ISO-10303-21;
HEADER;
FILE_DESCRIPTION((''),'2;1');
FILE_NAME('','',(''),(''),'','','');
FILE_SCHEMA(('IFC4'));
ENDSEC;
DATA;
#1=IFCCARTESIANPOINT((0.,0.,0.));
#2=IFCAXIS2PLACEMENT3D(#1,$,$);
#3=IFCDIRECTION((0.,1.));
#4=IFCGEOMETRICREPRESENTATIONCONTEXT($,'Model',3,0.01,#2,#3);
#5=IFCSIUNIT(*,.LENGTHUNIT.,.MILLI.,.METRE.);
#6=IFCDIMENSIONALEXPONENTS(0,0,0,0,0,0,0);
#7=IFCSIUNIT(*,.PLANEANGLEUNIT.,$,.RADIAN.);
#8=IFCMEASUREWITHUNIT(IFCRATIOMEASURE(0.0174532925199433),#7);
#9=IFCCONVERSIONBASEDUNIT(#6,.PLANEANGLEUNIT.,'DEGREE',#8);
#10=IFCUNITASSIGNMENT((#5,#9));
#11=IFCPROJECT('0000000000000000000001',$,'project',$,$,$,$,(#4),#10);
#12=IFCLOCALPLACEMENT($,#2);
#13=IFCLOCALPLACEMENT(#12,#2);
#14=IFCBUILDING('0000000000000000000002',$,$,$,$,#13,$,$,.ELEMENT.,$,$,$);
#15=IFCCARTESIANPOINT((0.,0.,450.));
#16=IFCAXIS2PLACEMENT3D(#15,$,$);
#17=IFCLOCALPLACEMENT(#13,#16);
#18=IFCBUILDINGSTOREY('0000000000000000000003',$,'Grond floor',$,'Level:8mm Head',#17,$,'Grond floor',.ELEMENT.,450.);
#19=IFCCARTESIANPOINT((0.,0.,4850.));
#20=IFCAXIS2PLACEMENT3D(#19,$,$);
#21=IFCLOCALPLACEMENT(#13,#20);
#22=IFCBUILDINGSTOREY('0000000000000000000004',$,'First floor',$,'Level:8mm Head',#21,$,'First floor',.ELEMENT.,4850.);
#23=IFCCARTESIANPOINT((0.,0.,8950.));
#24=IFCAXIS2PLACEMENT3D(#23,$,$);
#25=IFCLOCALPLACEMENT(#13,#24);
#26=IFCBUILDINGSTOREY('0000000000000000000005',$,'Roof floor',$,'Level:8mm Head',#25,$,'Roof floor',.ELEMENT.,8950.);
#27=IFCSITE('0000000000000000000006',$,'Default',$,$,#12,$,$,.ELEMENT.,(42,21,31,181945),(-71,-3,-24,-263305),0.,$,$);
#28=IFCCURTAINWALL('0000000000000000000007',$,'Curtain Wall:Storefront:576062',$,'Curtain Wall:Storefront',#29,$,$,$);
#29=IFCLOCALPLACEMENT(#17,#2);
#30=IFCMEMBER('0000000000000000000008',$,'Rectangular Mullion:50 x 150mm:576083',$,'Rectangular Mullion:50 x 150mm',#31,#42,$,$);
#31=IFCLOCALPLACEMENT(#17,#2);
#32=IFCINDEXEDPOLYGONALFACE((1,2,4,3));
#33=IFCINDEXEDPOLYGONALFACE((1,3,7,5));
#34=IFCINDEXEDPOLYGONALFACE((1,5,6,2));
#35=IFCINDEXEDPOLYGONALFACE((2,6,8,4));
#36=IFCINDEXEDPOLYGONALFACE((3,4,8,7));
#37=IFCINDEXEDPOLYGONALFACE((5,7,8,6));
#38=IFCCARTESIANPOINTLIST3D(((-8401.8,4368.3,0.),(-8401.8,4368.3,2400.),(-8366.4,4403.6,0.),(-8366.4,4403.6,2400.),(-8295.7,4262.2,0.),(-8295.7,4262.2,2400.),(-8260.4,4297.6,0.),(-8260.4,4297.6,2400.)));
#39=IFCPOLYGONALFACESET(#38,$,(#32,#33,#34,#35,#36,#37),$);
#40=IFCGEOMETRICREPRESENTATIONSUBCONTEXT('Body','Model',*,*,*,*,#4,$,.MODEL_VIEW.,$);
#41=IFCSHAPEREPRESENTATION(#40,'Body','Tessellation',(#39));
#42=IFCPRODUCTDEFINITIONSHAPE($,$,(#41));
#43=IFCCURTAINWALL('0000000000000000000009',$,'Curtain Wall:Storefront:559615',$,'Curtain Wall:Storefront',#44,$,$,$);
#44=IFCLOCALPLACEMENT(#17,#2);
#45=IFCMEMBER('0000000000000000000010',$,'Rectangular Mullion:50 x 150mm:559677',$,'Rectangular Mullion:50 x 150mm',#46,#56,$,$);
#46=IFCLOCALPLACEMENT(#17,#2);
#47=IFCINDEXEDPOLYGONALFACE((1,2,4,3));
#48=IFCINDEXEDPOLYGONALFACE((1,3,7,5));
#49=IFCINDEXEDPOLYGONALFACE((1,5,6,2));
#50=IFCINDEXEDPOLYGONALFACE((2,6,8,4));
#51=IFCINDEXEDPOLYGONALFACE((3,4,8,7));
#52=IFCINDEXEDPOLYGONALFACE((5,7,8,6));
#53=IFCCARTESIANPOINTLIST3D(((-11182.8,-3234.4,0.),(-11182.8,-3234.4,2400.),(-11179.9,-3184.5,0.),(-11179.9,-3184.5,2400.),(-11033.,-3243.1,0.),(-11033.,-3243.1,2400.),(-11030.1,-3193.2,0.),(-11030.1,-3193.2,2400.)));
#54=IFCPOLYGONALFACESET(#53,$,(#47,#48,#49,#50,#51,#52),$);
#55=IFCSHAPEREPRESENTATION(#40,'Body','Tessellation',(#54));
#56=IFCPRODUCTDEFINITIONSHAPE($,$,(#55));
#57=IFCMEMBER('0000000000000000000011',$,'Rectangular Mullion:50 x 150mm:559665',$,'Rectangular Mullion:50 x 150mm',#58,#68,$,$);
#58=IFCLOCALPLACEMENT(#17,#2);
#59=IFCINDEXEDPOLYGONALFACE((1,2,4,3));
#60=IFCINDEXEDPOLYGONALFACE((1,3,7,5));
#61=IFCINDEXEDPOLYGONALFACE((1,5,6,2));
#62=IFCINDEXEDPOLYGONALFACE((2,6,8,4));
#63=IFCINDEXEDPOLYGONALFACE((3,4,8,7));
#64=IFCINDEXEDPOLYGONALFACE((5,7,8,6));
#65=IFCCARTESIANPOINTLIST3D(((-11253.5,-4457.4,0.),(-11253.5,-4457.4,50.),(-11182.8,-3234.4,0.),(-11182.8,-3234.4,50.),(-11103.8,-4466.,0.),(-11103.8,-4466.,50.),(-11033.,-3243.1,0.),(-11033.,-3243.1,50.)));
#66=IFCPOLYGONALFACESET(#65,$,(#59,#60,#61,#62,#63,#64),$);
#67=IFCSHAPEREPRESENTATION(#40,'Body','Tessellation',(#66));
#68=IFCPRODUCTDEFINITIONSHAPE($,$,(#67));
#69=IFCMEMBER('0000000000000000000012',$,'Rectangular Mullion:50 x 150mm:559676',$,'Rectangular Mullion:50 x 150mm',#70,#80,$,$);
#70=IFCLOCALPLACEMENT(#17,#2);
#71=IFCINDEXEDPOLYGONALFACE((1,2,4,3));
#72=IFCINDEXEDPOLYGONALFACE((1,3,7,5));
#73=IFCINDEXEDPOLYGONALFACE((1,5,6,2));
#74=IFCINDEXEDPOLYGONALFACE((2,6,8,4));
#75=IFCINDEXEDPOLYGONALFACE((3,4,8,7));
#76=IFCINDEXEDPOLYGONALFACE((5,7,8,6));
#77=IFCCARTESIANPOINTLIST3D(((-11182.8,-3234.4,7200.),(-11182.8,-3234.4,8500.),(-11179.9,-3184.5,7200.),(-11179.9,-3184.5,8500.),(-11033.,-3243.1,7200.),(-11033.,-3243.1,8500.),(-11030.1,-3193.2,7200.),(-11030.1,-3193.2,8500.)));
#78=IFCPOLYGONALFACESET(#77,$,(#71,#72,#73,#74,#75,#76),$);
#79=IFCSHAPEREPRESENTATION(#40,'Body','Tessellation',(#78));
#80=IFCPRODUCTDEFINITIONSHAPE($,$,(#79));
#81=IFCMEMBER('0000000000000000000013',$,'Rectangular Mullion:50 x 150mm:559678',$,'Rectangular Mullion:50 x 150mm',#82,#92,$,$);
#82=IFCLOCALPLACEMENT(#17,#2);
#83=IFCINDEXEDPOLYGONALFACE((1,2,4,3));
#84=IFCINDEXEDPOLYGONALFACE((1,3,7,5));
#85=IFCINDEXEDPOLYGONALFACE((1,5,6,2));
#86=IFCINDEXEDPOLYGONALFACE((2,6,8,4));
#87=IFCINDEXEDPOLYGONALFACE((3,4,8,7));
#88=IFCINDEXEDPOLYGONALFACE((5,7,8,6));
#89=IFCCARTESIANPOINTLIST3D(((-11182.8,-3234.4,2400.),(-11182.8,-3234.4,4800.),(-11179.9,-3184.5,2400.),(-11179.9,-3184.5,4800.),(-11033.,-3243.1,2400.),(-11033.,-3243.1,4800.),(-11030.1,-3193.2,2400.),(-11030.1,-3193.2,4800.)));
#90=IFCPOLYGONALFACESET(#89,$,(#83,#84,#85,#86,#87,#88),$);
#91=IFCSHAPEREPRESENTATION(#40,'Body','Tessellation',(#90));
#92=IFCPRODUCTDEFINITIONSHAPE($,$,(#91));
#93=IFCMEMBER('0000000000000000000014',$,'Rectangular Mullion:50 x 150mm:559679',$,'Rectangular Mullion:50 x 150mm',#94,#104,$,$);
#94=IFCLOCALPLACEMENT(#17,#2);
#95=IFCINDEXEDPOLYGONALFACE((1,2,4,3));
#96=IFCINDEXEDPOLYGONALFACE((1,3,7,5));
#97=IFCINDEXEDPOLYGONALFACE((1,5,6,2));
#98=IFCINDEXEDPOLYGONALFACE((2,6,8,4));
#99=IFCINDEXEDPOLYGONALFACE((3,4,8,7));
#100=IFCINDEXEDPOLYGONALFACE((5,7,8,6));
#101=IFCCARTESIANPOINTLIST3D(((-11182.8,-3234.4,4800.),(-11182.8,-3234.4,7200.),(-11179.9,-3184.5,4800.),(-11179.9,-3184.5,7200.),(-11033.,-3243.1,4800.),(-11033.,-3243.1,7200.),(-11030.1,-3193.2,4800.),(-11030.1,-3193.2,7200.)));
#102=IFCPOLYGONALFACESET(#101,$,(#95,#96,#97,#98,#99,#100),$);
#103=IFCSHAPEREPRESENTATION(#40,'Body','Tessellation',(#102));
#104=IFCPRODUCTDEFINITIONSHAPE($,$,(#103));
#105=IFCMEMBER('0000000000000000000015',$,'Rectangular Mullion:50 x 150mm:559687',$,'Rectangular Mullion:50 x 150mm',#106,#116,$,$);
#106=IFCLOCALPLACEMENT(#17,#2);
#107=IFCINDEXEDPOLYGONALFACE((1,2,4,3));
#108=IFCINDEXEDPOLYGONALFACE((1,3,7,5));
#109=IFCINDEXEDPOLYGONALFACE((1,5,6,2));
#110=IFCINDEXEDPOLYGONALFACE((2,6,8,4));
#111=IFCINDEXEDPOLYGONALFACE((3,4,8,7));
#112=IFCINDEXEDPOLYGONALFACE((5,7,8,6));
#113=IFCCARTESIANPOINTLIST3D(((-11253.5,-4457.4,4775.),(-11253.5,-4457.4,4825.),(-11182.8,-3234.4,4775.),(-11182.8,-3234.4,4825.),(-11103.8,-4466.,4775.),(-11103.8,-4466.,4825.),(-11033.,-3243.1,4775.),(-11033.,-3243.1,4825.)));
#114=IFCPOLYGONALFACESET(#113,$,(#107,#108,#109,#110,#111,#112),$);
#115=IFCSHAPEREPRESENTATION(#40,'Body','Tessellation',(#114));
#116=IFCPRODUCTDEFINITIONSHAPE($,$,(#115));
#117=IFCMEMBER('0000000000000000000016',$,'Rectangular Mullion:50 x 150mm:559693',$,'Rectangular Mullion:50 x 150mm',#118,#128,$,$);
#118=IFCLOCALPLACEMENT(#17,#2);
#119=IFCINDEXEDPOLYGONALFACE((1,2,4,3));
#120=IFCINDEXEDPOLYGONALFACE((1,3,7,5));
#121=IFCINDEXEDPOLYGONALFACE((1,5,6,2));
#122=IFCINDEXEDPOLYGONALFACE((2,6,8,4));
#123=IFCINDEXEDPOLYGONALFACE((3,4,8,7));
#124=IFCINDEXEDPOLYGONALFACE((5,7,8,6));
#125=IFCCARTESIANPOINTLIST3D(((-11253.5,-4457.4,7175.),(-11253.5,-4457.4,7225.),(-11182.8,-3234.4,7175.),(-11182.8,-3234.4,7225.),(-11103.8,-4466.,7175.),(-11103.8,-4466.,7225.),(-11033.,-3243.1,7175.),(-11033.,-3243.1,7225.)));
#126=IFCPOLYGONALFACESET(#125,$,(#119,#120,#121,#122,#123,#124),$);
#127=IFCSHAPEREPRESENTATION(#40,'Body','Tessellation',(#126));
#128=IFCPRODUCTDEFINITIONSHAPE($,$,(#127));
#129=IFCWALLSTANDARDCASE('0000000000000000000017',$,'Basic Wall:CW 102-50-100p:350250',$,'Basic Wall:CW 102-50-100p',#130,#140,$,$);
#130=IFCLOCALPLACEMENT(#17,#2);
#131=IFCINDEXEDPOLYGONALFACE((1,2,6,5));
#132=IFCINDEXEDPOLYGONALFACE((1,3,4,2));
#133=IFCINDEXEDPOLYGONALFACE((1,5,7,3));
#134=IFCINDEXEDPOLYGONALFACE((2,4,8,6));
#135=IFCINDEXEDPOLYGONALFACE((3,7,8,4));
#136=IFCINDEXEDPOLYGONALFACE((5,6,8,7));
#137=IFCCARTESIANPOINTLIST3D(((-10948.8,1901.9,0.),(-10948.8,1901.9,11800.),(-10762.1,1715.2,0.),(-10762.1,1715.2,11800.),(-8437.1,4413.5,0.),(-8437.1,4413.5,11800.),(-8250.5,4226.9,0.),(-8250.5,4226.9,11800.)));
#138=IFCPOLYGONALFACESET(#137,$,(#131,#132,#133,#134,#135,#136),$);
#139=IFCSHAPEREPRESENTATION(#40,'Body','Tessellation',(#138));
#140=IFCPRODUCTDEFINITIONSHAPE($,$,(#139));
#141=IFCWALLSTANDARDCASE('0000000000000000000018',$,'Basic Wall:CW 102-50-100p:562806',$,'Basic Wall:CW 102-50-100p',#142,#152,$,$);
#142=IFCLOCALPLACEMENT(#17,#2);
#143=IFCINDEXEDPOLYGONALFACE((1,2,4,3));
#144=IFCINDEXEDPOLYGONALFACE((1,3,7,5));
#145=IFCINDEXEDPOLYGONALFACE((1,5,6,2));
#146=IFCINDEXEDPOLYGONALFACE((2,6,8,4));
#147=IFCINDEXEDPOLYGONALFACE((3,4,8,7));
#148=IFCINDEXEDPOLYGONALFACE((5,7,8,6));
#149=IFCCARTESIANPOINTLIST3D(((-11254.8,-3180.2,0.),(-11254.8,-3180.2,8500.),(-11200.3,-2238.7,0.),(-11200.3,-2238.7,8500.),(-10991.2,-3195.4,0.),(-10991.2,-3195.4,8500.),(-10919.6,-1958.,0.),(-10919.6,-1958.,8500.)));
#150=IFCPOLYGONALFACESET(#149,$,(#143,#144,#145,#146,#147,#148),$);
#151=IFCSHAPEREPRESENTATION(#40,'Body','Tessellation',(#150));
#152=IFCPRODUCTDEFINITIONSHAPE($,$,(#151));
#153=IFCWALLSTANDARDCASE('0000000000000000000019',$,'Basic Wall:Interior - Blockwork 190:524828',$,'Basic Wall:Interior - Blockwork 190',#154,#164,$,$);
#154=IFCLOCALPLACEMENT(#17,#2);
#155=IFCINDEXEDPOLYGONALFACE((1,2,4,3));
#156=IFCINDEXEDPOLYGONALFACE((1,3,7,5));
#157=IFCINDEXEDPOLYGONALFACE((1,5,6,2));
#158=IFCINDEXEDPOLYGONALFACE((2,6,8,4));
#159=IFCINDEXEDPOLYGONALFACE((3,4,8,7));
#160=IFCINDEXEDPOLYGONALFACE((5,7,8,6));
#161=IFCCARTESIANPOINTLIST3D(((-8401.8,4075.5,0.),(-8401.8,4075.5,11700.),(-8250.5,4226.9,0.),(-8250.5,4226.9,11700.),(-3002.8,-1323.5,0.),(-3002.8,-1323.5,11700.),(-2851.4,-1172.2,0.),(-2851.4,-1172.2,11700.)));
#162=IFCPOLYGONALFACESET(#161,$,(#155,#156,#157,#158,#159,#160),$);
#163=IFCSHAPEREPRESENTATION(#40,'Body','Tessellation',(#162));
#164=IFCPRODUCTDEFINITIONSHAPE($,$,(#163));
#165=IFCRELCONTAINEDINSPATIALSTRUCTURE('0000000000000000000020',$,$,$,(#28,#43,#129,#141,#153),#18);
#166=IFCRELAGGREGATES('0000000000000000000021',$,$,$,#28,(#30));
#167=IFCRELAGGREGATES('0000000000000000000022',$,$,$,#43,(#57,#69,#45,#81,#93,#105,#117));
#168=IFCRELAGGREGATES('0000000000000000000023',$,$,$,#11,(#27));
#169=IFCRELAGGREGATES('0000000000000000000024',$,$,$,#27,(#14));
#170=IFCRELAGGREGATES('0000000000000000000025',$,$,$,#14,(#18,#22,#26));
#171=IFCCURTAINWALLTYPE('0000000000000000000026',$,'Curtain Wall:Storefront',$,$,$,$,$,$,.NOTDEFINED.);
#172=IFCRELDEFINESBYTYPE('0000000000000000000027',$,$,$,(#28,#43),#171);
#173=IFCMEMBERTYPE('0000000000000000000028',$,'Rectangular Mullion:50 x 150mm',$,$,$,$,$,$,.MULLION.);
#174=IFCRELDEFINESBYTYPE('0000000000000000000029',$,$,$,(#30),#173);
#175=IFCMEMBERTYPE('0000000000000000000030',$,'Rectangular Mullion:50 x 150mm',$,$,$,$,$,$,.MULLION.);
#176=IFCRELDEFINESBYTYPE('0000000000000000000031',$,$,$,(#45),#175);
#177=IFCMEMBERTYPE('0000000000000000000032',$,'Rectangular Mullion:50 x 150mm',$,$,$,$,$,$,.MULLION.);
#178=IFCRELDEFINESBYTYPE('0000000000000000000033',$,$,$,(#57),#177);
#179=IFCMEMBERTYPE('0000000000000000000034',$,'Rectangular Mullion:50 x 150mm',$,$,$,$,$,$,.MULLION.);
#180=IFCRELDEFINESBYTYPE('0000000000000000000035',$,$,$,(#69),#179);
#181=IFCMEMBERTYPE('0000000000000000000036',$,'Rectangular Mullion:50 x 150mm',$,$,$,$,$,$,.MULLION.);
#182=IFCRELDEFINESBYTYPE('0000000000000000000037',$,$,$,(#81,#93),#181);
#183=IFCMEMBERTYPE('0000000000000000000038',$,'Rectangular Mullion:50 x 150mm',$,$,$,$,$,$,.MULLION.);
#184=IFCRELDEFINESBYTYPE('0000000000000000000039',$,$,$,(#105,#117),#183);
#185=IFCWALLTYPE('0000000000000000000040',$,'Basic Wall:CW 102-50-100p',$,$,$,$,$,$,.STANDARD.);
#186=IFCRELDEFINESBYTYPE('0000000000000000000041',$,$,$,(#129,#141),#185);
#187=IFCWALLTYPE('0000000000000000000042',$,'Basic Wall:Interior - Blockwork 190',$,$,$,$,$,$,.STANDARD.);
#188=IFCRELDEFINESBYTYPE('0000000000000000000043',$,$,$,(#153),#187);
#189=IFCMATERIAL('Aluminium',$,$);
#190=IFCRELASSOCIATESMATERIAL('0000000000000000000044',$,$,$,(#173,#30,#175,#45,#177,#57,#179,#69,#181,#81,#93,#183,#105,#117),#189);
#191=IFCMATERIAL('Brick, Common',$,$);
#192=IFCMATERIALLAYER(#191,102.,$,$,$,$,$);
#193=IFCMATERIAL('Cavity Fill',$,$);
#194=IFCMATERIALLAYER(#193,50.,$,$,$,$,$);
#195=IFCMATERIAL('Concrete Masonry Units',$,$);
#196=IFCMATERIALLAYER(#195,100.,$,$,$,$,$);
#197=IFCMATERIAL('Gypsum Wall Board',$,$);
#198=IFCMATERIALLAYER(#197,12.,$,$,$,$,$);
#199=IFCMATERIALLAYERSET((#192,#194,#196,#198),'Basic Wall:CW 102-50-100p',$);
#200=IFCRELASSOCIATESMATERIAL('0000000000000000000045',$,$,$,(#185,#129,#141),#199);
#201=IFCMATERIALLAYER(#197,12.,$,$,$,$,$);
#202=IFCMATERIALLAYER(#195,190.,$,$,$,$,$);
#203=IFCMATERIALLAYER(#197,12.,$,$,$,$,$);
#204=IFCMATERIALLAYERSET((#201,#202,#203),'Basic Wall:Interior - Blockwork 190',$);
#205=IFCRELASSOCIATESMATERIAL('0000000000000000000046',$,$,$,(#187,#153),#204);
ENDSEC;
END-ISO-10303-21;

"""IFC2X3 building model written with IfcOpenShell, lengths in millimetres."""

from ifc_helpers import new_model, entity, si_unit, converted_unit, direction, frame, frame_2d, origin, origin_2d_with_axis, place, context, subcontext, project, spatial, polyline, rectangle, outline, extrude, source, transform, mapped, material, layer, layer_set, layer_usage, type_object, type_shapes, element, aggregate, save


model = new_model("IFC2X3")

# Units and contexts
model_context = context("Model", 3, precision=0.01, world=origin(), true_north=direction((0.0, 1.0)))
body_context = subcontext(model_context, "Body", "Model", "MODEL_VIEW")
ifc_project = project(units=[si_unit("LENGTHUNIT", "METRE", prefix="MILLI"), converted_unit("PLANEANGLEUNIT", "DEGREE", entity("IfcRatioMeasure", 0.0174532925199433), si_unit("PLANEANGLEUNIT", "RADIAN"), dimensions=[0, 0, 0, 0, 0, 0, 0])], contexts=[model_context])

# Site, building, storey
site_placement = place(None, origin())
site = spatial("IfcSite", under=ifc_project, at=site_placement, Name="Default", CompositionType="ELEMENT", RefLatitude=(42, 21, 31, 181945), RefLongitude=(-71, -3, -24, -263305), RefElevation=0.0)
building_placement = place(site_placement, origin())
building = spatial("IfcBuilding", under=site, at=building_placement, CompositionType="ELEMENT")
storey_1_placement = place(building_placement, frame((0.0, 0.0, 450.0)))
storey_1 = spatial("IfcBuildingStorey", under=building, at=storey_1_placement, Name="Grond floor", ObjectType="Level:8mm Head", LongName="Grond floor", CompositionType="ELEMENT", Elevation=450.0)

# Curtain wall, member
curtain_wall_type = type_object("IfcCurtainWallType", Name="Curtain Wall:Storefront", PredefinedType="NOTDEFINED")
curtain_wall_1_placement = place(storey_1_placement, frame((0.0, 0.0, -450.0)))
curtain_wall_1 = element("IfcCurtainWall", 1, at=curtain_wall_1_placement, inside=storey_1, type_object=curtain_wall_type, Name="Curtain Wall:Storefront:576062", ObjectType="Curtain Wall:Storefront")
ifc_material_1 = material(Name="Aluminium")
member_type_1 = type_object("IfcMemberType", Name="Rectangular Mullion:50 x 150mm", PredefinedType="MULLION", material=ifc_material_1)
shared_shape_1 = source(origin(), body_context, "Body", "SweptSolid", [
    extrude(rectangle(XDim=150.0, YDim=50.0, at=origin_2d_with_axis()), frame((-25.0, 0.0, -2400.0), z_axis=(0.0, 0.0, 1.0), x_axis=(0.0, -1.0, 0.0)), (0.0, 0.0, 1.0), 2400.0),
])
type_shapes(member_type_1, [shared_shape_1])
member_1_placement = place(storey_1_placement, frame((-8348.8, 4315.3, 0.0), z_axis=(0.0, 0.0, -1.0), x_axis=(-0.707107, -0.707107, 0.0)))
member_1 = element("IfcMember", 2, at=member_1_placement, type_object=member_type_1, material=ifc_material_1, Name="Rectangular Mullion:50 x 150mm:576083", ObjectType="Rectangular Mullion:50 x 150mm", context=body_context, shape_type="MappedRepresentation", body=[
    mapped(shared_shape_1, transform((0.0, 0.0, 0.0), scale=1.0)),
])
aggregate(curtain_wall_1, [member_1])

# Curtain wall, members
curtain_wall_2_placement = place(storey_1_placement, frame((0.0, 0.0, -450.0)))
curtain_wall_2 = element("IfcCurtainWall", 3, at=curtain_wall_2_placement, inside=storey_1, type_object=curtain_wall_type, Name="Curtain Wall:Storefront:559615", ObjectType="Curtain Wall:Storefront")
member_type_2 = type_object("IfcMemberType", Name="Rectangular Mullion:50 x 150mm", PredefinedType="MULLION", material=ifc_material_1)
shared_shape_2 = source(origin(), body_context, "Body", "SweptSolid", [
    extrude(rectangle(XDim=150.0, YDim=50.0, at=origin_2d_with_axis()), frame((-25.0, 0.0, -2400.0), z_axis=(0.0, 0.0, 1.0), x_axis=(0.0, -1.0, 0.0)), (0.0, 0.0, 1.0), 2400.0),
])
type_shapes(member_type_2, [shared_shape_2])
member_2_placement = place(storey_1_placement, frame((-11105.0, -3188.8, 2400.0), z_axis=(0.0, 0.0, 1.0), x_axis=(0.057751, 0.998331, 0.0)))
member_2 = element("IfcMember", 4, at=member_2_placement, type_object=member_type_2, material=ifc_material_1, Name="Rectangular Mullion:50 x 150mm:559677", ObjectType="Rectangular Mullion:50 x 150mm", context=body_context, shape_type="MappedRepresentation", body=[
    mapped(shared_shape_2, transform((0.0, 0.0, 0.0), scale=1.0)),
])
member_type_3 = type_object("IfcMemberType", Name="Rectangular Mullion:50 x 150mm", PredefinedType="MULLION", material=ifc_material_1)
shared_shape_3 = source(origin(), body_context, "Body", "SweptSolid", [
    extrude(rectangle(XDim=150.0, YDim=50.0, at=origin_2d_with_axis()), frame((-25.0, 0.0, -1225.0), z_axis=(0.0, 0.0, 1.0), x_axis=(0.0, -1.0, 0.0)), (0.0, 0.0, 1.0), 1225.0),
])
type_shapes(member_type_3, [shared_shape_3])
member_3_placement = place(storey_1_placement, frame((-11107.9, -3238.7, 0.0), z_axis=(0.057751, 0.998331, 0.0), x_axis=(0.0, 0.0, -1.0)))
member_3 = element("IfcMember", 5, at=member_3_placement, type_object=member_type_3, material=ifc_material_1, Name="Rectangular Mullion:50 x 150mm:559665", ObjectType="Rectangular Mullion:50 x 150mm", context=body_context, shape_type="MappedRepresentation", body=[
    mapped(shared_shape_3, transform((0.0, 0.0, 0.0), scale=1.0)),
])
member_type_4 = type_object("IfcMemberType", Name="Rectangular Mullion:50 x 150mm", PredefinedType="MULLION", material=ifc_material_1)
shared_shape_4 = source(origin(), body_context, "Body", "SweptSolid", [
    extrude(rectangle(XDim=150.0, YDim=50.0, at=origin_2d_with_axis()), frame((-25.0, 0.0, -1300.0), z_axis=(0.0, 0.0, 1.0), x_axis=(0.0, -1.0, 0.0)), (0.0, 0.0, 1.0), 1300.0),
])
type_shapes(member_type_4, [shared_shape_4])
member_4_placement = place(storey_1_placement, frame((-11105.0, -3188.8, 8500.0), z_axis=(0.0, 0.0, 1.0), x_axis=(0.057751, 0.998331, 0.0)))
member_4 = element("IfcMember", 6, at=member_4_placement, type_object=member_type_4, material=ifc_material_1, Name="Rectangular Mullion:50 x 150mm:559676", ObjectType="Rectangular Mullion:50 x 150mm", context=body_context, shape_type="MappedRepresentation", body=[
    mapped(shared_shape_4, transform((0.0, 0.0, 0.0), scale=1.0)),
])
member_type_5 = type_object("IfcMemberType", Name="Rectangular Mullion:50 x 150mm", PredefinedType="MULLION", material=ifc_material_1)
shared_shape_5 = source(origin(), body_context, "Body", "SweptSolid", [
    extrude(rectangle(XDim=150.0, YDim=50.0, at=origin_2d_with_axis()), frame((-25.0, 0.0, -2400.0), z_axis=(0.0, 0.0, 1.0), x_axis=(0.0, -1.0, 0.0)), (0.0, 0.0, 1.0), 2400.0),
])
type_shapes(member_type_5, [shared_shape_5])
member_5_placement = place(storey_1_placement, frame((-11105.0, -3188.8, 4800.0), z_axis=(0.0, 0.0, 1.0), x_axis=(0.057751, 0.998331, 0.0)))
member_5 = element("IfcMember", 7, at=member_5_placement, type_object=member_type_5, material=ifc_material_1, Name="Rectangular Mullion:50 x 150mm:559678", ObjectType="Rectangular Mullion:50 x 150mm", context=body_context, shape_type="MappedRepresentation", body=[
    mapped(shared_shape_5, transform((0.0, 0.0, 0.0), scale=1.0)),
])
member_6_placement = place(storey_1_placement, frame((-11105.0, -3188.8, 7200.0), z_axis=(0.0, 0.0, 1.0), x_axis=(0.057751, 0.998331, 0.0)))
member_6 = element("IfcMember", 8, at=member_6_placement, type_object=member_type_5, material=ifc_material_1, Name="Rectangular Mullion:50 x 150mm:559679", ObjectType="Rectangular Mullion:50 x 150mm", context=body_context, shape_type="MappedRepresentation", body=[
    mapped(shared_shape_5, transform((0.0, 0.0, 0.0), scale=1.0)),
])
member_type_6 = type_object("IfcMemberType", Name="Rectangular Mullion:50 x 150mm", PredefinedType="MULLION", material=ifc_material_1)
shared_shape_6 = source(origin(), body_context, "Body", "SweptSolid", [
    extrude(rectangle(XDim=150.0, YDim=50.0, at=origin_2d_with_axis()), frame((0.0, 0.0, -1225.0), z_axis=(0.0, 0.0, 1.0), x_axis=(0.0, -1.0, 0.0)), (0.0, 0.0, 1.0), 1225.0),
])
type_shapes(member_type_6, [shared_shape_6])
member_7_placement = place(storey_1_placement, frame((-11178.6, -4461.7, 4800.0), z_axis=(-0.057751, -0.998331, 0.0), x_axis=(0.0, 0.0, 1.0)))
member_7 = element("IfcMember", 9, at=member_7_placement, type_object=member_type_6, material=ifc_material_1, Name="Rectangular Mullion:50 x 150mm:559687", ObjectType="Rectangular Mullion:50 x 150mm", context=body_context, shape_type="MappedRepresentation", body=[
    mapped(shared_shape_6, transform((0.0, 0.0, 0.0), scale=1.0)),
])
member_8_placement = place(storey_1_placement, frame((-11178.6, -4461.7, 7200.0), z_axis=(-0.057751, -0.998331, 0.0), x_axis=(0.0, 0.0, 1.0)))
member_8 = element("IfcMember", 10, at=member_8_placement, type_object=member_type_6, material=ifc_material_1, Name="Rectangular Mullion:50 x 150mm:559693", ObjectType="Rectangular Mullion:50 x 150mm", context=body_context, shape_type="MappedRepresentation", body=[
    mapped(shared_shape_6, transform((0.0, 0.0, 0.0), scale=1.0)),
])
aggregate(curtain_wall_2, [member_3, member_4, member_2, member_5, member_6, member_7, member_8])

# Walls
ifc_material_2 = material(Name="Brick, Common")
ifc_layer_1 = layer(ifc_material_2, 102.0)
ifc_material_3 = material(Name="Cavity Fill")
ifc_layer_2 = layer(ifc_material_3, 50.0)
ifc_material_4 = material(Name="Concrete Masonry Units")
ifc_layer_3 = layer(ifc_material_4, 100.0)
ifc_material_5 = material(Name="Gypsum Wall Board")
ifc_layer_4 = layer(ifc_material_5, 12.0)
ifc_layer_set_1 = layer_set([ifc_layer_1, ifc_layer_2, ifc_layer_3, ifc_layer_4], Name="Basic Wall:CW 102-50-100p")
ifc_layer_usage_1 = layer_usage(ifc_layer_set_1, "AXIS2", "POSITIVE", -132.0)
wall_type_1 = type_object("IfcWallType", Name="Basic Wall:CW 102-50-100p", PredefinedType="STANDARD", material=ifc_layer_set_1)
wall_1_placement = place(storey_1_placement, frame((-10855.4, 1808.6, 0.0), z_axis=(0.0, 0.0, 1.0), x_axis=(0.707107, 0.707107, 0.0)))
element("IfcWallStandardCase", 11, at=wall_1_placement, inside=storey_1, type_object=wall_type_1, material=ifc_layer_usage_1, Name="Basic Wall:CW 102-50-100p:350250", ObjectType="Basic Wall:CW 102-50-100p", context=body_context, shape_type="SweptSolid", body=[
    extrude(rectangle(XDim=3552.0, YDim=264.0, at=frame_2d((1776.0, 0.0), x_axis=(-1.0, 0.0))), origin(), (0.0, 0.0, 1.0), 11800.0),
])
ifc_layer_usage_2 = layer_usage(ifc_layer_set_1, "AXIS2", "POSITIVE", -132.0)
wall_2_placement = place(storey_1_placement, frame((-11051.4, -1950.4, 0.0), z_axis=(0.0, 0.0, 1.0), x_axis=(-0.057751, -0.998331, 0.0)))
element("IfcWallStandardCase", 12, at=wall_2_placement, inside=storey_1, type_object=wall_type_1, material=ifc_layer_usage_2, Name="Basic Wall:CW 102-50-100p:562806", ObjectType="Basic Wall:CW 102-50-100p", context=body_context, shape_type="SweptSolid", body=[
    extrude(outline(polyline([(1239.5, -132.0), (1239.5, 132.0), (0.0, 132.0), (296.4, -132.0), (1239.5, -132.0)])), origin(), (0.0, 0.0, 1.0), 8500.0),
])
ifc_layer_5 = layer(ifc_material_5, 12.0)
ifc_layer_6 = layer(ifc_material_4, 190.0)
ifc_layer_7 = layer(ifc_material_5, 12.0)
ifc_layer_set_2 = layer_set([ifc_layer_5, ifc_layer_6, ifc_layer_7], Name="Basic Wall:Interior - Blockwork 190")
ifc_layer_usage_3 = layer_usage(ifc_layer_set_2, "AXIS2", "NEGATIVE", 107.0)
wall_type_2 = type_object("IfcWallType", Name="Basic Wall:Interior - Blockwork 190", PredefinedType="STANDARD", material=ifc_layer_set_2)
wall_3_placement = place(storey_1_placement, frame((-8326.1, 4151.2, 0.0), z_axis=(0.0, 0.0, 1.0), x_axis=(0.707107, -0.707107, 0.0)))
element("IfcWallStandardCase", 13, at=wall_3_placement, inside=storey_1, type_object=wall_type_2, material=ifc_layer_usage_3, Name="Basic Wall:Interior - Blockwork 190:524828", ObjectType="Basic Wall:Interior - Blockwork 190", context=body_context, shape_type="SweptSolid", body=[
    extrude(rectangle(XDim=7635.4, YDim=214.0, at=frame_2d((3817.7, 0.0), x_axis=(-1.0, 0.0))), origin(), (0.0, 0.0, 1.0), 11700.0),
])

# Shared definitions
storey_2_placement = place(building_placement, frame((0.0, 0.0, 4850.0)))
storey_2 = spatial("IfcBuildingStorey", under=building, at=storey_2_placement, Name="First floor", ObjectType="Level:8mm Head", LongName="First floor", CompositionType="ELEMENT", Elevation=4850.0)

# Shared definitions
storey_3_placement = place(building_placement, frame((0.0, 0.0, 8950.0)))
storey_3 = spatial("IfcBuildingStorey", under=building, at=storey_3_placement, Name="Roof floor", ObjectType="Level:8mm Head", LongName="Roof floor", CompositionType="ELEMENT", Elevation=8950.0)

save(model, "model.ifc")
